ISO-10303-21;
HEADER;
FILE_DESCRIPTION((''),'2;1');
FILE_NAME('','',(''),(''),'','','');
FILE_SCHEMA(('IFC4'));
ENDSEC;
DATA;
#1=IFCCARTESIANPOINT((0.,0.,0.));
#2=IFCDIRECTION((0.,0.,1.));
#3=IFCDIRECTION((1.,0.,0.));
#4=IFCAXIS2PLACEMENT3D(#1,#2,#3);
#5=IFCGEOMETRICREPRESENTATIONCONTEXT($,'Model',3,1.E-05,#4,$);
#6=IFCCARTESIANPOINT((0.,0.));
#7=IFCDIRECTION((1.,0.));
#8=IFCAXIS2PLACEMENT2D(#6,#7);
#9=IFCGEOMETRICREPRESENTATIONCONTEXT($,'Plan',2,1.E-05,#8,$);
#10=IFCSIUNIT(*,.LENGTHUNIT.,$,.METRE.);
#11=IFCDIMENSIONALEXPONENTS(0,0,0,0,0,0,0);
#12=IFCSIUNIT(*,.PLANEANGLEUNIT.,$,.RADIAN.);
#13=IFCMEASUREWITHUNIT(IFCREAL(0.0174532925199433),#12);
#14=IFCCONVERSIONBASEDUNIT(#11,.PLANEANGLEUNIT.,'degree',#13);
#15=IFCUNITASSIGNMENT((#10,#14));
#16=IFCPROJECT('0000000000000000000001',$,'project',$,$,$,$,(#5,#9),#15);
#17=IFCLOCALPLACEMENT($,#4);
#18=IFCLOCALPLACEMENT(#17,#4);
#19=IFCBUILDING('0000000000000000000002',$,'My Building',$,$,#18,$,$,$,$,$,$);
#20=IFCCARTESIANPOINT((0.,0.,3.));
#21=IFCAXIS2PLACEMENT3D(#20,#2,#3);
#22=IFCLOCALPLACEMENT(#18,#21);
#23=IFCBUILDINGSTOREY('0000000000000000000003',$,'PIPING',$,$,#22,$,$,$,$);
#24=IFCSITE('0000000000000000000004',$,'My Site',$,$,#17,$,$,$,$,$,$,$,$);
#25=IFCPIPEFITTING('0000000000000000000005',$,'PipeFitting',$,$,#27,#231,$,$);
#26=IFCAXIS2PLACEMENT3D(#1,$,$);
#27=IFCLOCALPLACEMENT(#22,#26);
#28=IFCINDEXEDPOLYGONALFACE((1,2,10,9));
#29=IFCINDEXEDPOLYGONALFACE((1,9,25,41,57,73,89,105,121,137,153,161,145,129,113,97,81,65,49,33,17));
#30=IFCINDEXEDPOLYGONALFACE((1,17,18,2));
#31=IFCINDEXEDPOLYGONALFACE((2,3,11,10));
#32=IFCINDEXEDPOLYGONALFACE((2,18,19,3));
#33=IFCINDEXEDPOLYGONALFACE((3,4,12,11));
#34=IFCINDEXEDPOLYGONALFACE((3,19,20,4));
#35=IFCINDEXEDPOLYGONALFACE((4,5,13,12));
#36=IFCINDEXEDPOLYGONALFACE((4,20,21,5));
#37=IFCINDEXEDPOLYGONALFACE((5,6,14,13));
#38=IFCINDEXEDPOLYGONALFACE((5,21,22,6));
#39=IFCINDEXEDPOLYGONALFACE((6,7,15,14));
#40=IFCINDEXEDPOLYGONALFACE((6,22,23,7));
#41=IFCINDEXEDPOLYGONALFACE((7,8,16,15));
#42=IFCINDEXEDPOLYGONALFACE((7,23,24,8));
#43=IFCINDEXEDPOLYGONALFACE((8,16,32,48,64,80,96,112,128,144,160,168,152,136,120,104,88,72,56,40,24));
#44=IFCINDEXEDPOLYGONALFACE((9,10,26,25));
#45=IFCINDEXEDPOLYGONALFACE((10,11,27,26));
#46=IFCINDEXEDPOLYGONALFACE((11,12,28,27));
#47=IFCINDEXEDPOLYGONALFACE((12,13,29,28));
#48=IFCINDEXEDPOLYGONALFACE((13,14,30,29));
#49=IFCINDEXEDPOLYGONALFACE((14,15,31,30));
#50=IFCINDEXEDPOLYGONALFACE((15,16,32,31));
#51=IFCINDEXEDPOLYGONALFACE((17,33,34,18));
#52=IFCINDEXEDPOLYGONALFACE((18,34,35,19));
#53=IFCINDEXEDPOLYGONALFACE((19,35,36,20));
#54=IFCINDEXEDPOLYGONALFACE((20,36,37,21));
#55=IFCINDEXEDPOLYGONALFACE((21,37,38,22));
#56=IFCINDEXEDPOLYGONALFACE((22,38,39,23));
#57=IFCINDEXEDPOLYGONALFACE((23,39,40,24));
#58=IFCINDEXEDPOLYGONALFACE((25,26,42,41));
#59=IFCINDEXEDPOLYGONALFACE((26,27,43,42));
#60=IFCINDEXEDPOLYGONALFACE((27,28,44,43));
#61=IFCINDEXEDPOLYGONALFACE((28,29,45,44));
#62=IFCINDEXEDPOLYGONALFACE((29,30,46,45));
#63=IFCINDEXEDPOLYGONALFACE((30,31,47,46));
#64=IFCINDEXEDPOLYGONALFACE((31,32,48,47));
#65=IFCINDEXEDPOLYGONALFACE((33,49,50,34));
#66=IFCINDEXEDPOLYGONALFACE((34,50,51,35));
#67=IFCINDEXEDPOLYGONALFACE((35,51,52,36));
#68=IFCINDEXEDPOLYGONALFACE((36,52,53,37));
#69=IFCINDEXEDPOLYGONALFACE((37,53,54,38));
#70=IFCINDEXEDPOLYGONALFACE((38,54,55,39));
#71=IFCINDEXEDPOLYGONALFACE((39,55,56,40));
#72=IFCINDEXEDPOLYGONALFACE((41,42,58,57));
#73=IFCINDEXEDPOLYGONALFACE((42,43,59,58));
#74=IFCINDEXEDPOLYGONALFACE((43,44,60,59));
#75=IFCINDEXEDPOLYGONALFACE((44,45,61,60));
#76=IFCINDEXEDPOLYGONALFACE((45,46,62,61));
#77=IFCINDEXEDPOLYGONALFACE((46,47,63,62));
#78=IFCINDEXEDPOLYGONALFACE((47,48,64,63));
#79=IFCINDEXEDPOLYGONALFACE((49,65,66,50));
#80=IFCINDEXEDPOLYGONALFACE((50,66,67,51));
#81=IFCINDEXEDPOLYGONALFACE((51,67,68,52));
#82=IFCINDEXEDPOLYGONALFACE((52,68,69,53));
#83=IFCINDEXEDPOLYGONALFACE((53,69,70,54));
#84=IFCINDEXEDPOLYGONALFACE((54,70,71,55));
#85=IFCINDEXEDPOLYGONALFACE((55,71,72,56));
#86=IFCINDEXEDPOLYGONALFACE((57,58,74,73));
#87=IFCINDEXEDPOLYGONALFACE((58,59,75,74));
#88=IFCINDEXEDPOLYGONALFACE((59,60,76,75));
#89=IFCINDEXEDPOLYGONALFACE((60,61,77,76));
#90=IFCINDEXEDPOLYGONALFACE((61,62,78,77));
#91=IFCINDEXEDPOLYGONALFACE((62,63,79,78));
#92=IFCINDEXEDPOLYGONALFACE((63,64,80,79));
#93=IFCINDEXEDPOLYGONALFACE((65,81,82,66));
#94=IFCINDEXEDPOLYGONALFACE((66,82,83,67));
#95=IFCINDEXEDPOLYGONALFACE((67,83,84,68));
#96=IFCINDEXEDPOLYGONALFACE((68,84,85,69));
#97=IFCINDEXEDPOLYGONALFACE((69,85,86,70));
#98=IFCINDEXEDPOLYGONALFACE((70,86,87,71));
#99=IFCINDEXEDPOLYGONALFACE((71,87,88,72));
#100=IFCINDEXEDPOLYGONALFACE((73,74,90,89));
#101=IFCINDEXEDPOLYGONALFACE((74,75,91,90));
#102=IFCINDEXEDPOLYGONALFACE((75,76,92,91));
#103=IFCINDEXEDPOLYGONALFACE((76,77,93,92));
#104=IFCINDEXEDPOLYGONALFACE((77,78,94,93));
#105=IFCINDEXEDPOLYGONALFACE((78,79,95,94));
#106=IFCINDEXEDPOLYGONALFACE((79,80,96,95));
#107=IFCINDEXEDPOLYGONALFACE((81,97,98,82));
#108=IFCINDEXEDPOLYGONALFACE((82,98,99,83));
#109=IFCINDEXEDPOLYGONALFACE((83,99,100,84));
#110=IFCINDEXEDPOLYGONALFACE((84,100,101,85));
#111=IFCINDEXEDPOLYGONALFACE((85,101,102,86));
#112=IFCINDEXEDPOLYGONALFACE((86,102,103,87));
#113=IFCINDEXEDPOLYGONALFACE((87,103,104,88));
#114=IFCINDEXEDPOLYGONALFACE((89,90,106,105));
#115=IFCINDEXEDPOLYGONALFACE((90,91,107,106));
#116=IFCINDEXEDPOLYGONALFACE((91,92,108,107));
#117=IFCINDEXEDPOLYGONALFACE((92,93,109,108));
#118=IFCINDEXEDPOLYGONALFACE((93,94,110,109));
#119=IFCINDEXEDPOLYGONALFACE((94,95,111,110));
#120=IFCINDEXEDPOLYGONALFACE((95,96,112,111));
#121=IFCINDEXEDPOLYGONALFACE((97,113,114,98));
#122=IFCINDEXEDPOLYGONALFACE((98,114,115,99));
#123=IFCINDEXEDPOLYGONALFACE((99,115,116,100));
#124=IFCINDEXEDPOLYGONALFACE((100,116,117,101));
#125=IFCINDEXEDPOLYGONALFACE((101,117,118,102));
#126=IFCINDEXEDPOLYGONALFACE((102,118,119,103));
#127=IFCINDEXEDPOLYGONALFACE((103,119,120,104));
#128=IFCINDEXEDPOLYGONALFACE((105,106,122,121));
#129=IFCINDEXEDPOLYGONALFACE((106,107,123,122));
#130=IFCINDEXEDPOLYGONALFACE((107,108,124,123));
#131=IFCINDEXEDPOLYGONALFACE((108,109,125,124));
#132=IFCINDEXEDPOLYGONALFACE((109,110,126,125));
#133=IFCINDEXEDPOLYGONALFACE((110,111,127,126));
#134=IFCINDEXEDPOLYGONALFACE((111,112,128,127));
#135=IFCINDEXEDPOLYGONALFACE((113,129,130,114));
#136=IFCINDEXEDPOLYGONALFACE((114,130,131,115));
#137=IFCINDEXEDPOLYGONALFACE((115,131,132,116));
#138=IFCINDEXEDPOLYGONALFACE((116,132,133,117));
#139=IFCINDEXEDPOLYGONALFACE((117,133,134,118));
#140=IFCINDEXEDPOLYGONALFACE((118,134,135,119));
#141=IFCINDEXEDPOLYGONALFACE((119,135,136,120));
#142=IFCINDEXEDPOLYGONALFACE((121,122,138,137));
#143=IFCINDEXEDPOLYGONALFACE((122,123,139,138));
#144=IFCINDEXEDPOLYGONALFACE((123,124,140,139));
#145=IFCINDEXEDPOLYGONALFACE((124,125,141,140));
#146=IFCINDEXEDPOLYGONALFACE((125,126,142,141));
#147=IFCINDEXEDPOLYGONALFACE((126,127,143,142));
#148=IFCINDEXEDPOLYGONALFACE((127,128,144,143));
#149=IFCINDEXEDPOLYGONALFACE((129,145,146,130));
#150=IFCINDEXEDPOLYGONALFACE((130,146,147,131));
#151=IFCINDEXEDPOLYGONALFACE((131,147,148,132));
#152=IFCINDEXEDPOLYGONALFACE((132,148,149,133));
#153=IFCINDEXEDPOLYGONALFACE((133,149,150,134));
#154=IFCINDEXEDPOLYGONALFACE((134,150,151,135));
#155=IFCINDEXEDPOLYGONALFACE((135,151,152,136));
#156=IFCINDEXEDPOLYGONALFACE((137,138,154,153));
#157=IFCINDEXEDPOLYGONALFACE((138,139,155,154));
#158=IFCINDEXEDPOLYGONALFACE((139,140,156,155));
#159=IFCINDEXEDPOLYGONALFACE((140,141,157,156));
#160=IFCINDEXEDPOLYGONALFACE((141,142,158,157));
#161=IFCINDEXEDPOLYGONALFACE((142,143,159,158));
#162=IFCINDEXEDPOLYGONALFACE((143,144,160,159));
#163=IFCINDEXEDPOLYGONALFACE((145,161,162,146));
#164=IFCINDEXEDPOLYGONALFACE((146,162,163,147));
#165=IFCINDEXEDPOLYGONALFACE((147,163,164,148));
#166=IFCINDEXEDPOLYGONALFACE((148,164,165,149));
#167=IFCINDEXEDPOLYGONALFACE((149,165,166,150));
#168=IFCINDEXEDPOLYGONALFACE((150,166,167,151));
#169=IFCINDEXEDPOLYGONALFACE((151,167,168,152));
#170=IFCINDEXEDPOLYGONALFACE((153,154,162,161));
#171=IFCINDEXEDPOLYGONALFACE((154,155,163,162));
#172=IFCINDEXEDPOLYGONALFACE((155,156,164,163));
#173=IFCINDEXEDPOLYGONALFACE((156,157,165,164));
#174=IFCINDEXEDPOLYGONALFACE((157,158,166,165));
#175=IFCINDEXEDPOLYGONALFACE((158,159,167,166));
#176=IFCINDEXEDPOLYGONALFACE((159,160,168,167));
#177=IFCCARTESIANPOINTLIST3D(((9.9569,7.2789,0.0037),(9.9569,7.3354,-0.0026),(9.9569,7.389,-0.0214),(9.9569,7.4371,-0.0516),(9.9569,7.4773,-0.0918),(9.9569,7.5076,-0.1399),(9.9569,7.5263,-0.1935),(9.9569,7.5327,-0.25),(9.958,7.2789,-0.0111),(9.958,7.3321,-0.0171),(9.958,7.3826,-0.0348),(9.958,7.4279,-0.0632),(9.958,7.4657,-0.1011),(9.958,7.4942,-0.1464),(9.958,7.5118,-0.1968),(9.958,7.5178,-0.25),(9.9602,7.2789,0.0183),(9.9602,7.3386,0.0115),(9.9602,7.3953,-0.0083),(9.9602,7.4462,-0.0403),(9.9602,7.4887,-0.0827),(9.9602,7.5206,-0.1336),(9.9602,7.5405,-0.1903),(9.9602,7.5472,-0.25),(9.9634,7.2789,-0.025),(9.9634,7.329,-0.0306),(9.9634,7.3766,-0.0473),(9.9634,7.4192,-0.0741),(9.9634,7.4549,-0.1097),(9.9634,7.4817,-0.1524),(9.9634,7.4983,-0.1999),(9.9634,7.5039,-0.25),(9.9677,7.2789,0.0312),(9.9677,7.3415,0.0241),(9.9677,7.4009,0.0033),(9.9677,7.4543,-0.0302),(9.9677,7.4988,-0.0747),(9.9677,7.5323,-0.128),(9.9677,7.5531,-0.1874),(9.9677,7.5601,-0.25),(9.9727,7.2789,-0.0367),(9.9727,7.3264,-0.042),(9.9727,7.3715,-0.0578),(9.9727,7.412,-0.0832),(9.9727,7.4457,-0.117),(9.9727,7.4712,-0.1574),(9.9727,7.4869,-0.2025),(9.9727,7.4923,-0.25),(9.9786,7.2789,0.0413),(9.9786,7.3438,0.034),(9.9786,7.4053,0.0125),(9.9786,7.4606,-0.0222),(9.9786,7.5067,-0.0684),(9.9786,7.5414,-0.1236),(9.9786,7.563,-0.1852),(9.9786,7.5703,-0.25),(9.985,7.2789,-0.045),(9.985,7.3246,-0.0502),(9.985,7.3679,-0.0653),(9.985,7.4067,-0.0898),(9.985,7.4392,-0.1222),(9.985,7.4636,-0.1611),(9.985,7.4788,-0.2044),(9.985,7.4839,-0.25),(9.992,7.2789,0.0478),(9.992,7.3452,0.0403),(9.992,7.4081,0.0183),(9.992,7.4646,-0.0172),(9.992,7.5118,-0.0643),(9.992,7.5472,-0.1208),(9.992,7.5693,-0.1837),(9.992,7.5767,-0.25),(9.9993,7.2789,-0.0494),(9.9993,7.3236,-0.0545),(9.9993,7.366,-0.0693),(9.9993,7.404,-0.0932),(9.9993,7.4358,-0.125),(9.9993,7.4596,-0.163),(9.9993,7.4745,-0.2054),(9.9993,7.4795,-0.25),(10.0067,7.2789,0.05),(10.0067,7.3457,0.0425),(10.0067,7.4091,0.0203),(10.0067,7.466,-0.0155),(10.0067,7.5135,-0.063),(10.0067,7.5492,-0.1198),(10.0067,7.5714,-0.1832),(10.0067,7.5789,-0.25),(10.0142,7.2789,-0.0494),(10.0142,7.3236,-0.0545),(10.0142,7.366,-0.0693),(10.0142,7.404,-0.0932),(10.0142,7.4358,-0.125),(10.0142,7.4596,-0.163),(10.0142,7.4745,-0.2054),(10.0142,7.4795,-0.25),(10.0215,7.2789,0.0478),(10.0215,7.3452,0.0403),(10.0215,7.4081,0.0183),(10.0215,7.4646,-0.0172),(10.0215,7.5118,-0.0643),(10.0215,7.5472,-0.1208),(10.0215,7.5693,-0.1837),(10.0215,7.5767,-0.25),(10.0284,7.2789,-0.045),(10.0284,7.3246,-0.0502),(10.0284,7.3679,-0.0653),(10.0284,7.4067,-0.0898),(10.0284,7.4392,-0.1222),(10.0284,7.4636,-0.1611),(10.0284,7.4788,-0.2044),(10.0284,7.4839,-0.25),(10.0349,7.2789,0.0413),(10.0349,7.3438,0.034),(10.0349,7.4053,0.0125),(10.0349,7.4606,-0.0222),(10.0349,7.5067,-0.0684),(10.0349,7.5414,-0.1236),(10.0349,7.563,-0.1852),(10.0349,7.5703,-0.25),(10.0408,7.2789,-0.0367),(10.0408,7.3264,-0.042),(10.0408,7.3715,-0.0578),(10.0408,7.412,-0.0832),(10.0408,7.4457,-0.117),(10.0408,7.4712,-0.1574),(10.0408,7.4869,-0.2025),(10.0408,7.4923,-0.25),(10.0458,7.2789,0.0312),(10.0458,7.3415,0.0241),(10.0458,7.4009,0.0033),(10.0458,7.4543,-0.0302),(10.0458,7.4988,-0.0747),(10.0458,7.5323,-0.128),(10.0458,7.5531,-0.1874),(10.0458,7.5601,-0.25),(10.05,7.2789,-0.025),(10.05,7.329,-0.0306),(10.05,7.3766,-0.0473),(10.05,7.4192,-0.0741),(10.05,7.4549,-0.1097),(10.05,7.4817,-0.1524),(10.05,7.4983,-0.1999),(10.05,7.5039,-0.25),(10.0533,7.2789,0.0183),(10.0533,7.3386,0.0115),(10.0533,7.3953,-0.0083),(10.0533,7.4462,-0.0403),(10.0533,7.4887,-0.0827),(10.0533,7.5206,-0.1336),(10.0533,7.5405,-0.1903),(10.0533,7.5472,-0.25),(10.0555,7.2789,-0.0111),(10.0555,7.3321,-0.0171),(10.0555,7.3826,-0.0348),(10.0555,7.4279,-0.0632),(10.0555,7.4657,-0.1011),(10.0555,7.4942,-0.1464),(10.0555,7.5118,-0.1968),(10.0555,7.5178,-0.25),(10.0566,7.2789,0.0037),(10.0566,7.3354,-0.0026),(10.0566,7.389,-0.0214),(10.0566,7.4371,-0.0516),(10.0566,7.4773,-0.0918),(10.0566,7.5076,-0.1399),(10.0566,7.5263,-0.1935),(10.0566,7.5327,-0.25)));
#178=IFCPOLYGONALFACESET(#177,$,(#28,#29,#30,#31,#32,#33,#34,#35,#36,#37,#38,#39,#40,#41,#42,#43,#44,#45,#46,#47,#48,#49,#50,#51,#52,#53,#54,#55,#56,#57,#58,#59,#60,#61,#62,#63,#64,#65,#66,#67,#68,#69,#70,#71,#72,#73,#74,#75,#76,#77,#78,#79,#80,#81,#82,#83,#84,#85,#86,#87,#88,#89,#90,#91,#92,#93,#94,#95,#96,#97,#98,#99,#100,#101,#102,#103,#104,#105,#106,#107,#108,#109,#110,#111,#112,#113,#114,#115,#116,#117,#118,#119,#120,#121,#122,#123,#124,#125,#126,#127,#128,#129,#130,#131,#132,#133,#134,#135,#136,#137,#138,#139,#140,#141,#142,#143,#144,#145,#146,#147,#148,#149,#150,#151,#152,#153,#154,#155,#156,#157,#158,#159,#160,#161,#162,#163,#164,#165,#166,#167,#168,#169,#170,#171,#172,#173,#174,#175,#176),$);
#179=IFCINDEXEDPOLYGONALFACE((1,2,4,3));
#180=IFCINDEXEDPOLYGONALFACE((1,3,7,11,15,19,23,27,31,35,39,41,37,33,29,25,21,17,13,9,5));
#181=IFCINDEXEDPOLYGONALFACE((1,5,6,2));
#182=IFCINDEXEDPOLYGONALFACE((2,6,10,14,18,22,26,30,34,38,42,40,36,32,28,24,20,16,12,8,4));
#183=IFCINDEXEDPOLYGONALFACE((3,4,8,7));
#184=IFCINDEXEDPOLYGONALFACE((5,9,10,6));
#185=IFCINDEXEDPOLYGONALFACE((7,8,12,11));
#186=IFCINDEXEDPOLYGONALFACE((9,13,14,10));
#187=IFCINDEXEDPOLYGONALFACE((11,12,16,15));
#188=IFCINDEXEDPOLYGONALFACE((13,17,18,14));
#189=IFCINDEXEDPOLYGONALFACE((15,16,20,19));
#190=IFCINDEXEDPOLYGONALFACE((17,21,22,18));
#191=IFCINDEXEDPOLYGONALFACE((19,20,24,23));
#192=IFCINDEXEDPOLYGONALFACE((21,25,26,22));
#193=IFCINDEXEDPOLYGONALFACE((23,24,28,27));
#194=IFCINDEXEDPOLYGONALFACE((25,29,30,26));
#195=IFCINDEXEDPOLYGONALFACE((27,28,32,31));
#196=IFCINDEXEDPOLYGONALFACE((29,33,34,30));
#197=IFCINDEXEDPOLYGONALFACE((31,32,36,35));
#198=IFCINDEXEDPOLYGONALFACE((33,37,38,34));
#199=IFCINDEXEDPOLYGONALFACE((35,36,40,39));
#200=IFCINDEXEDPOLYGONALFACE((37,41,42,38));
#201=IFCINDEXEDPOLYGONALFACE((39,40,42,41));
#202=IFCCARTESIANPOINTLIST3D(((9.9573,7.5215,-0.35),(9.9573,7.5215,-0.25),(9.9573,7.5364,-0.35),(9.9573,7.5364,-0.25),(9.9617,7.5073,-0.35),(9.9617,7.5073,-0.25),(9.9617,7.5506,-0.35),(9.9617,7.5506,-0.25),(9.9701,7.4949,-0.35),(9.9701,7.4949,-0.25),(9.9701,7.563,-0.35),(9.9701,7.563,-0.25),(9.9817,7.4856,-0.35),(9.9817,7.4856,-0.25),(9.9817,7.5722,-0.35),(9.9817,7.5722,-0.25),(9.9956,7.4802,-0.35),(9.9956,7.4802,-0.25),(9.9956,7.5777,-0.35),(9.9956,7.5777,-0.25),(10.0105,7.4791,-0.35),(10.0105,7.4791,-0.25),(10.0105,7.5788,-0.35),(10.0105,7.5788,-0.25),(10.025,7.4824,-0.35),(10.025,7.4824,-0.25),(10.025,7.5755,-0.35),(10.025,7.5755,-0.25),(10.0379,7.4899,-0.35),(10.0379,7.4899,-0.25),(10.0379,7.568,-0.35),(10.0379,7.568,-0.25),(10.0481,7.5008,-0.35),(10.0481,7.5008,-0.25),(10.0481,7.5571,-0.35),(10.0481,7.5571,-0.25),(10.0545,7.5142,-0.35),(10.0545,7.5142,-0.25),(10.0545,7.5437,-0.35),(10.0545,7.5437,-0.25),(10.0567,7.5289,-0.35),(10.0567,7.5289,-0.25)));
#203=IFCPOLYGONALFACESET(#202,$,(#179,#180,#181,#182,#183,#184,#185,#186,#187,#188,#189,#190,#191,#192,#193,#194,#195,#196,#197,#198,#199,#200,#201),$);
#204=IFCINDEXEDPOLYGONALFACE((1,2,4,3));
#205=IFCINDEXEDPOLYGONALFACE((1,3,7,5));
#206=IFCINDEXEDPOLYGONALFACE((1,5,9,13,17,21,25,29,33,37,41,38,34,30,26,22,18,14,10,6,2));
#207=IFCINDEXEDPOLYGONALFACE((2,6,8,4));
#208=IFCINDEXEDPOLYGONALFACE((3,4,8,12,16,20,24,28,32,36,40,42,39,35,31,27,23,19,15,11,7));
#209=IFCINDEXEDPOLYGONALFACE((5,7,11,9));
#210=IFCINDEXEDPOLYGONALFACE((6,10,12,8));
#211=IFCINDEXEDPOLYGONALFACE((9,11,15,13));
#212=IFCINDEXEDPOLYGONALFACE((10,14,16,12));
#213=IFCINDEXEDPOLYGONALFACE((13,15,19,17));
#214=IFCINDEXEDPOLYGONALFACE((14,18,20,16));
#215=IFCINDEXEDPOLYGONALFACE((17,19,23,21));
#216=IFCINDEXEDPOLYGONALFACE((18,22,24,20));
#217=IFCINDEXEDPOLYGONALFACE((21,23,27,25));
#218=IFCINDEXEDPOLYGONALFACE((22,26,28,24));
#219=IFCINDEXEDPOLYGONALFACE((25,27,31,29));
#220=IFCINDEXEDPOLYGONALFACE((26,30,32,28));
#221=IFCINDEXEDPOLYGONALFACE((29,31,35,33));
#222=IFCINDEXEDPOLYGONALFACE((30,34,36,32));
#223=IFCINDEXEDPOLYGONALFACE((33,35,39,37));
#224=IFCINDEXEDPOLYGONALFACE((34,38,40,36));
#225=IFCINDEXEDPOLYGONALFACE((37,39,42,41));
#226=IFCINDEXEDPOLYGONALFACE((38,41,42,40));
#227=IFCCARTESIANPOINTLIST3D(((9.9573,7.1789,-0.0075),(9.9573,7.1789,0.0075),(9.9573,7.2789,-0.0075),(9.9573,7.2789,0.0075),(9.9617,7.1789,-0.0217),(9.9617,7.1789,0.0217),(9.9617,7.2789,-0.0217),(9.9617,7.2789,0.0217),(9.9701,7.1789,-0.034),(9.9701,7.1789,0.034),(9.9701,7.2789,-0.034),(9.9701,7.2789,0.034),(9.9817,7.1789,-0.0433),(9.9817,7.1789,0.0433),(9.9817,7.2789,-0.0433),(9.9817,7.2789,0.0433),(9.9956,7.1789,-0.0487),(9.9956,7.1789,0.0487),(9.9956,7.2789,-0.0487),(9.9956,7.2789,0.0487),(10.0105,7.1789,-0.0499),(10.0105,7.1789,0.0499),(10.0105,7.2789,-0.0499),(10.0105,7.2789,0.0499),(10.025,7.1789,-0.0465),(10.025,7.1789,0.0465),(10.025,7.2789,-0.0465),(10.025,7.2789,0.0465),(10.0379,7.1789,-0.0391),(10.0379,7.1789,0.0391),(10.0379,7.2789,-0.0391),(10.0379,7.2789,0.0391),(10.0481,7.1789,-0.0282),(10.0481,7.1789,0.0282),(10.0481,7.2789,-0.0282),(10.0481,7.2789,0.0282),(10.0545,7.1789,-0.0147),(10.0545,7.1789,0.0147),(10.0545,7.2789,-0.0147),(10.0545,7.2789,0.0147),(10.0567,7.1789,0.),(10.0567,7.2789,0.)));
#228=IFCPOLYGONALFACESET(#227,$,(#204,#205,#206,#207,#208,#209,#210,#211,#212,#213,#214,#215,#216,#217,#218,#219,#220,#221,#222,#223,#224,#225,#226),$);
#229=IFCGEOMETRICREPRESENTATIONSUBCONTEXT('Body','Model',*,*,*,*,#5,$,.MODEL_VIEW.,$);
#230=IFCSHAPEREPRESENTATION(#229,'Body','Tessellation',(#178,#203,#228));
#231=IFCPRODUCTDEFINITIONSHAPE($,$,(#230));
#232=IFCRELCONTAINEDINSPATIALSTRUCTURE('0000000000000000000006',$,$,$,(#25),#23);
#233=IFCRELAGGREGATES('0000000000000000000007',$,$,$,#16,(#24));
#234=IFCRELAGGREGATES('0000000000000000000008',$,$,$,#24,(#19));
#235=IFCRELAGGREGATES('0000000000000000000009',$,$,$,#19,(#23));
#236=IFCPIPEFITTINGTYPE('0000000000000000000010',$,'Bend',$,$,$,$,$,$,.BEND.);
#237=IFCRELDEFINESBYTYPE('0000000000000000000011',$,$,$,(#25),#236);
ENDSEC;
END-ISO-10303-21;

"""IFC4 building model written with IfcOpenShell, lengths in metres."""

from ifc_helpers import new_model, entity, si_unit, converted_unit, frame, origin_with_axes, origin_2d_with_axis, place, context, subcontext, project, spatial, circle, extrude, source, transform, mapped, type_object, type_shapes, element, save


model = new_model("IFC4")

# Units and contexts
model_context = context("Model", 3, precision=1e-05, world=origin_with_axes())
plan_context = context("Plan", 2, precision=1e-05, world=origin_2d_with_axis())
body_context = subcontext(model_context, "Body", "Model", "MODEL_VIEW")
ifc_project = project(units=[si_unit("LENGTHUNIT", "METRE"), converted_unit("PLANEANGLEUNIT", "degree", entity("IfcReal", 0.0174532925199433), si_unit("PLANEANGLEUNIT", "RADIAN"), dimensions=[0, 0, 0, 0, 0, 0, 0])], contexts=[model_context, plan_context])

# Site, building, storey
site_placement = place(None, origin_with_axes())
site = spatial("IfcSite", under=ifc_project, at=site_placement, Name="My Site")
building_placement = place(site_placement, origin_with_axes())
building = spatial("IfcBuilding", under=site, at=building_placement, Name="My Building")
storey_placement = place(building_placement, frame((0.0, 0.0, 3.0), z_axis=(0.0, 0.0, 1.0), x_axis=(1.0, 0.0, 0.0)))
storey = spatial("IfcBuildingStorey", under=building, at=storey_placement, Name="PIPING")

# Pipe fitting
pipe_fitting_type_1 = type_object("IfcPipeFittingType", Name="Bend", PredefinedType="BEND")
shared_shape = source(origin_with_axes(), body_context, "Body", "SolidModel", [
    entity("IfcSweptDiskSolid", entity("IfcIndexedPolyCurve", entity("IfcCartesianPointList3D", [[0.0, 0.0, -0.1], [0.0, 0.0732, -0.2768], [0.0, 0.25, -0.35]]), [entity("IfcArcIndex", [1, 2, 3])]), 0.05),
    extrude(circle(Radius=0.05), origin_with_axes(), (0.0, 0.0, -1.0), 0.1),
    extrude(circle(Radius=0.05), frame((0.0, 0.25, -0.35), z_axis=(0.0, 1.0, 0.0), x_axis=(1.0, 0.0, 0.0)), (0.0, 0.0, 1.0), 0.1),
])
type_shapes(pipe_fitting_type_1, [shared_shape])
for number, where, z_axis, x_axis, name in (
    (1, (10.0067, 7.5289, -0.35), (0.0, 0.0, -1.0), (1.0, 0.0, 0.0), "PipeFitting"),
):
    element("IfcPipeFitting", number, at=place(storey_placement, frame(where, z_axis=z_axis, x_axis=x_axis)), inside=storey, type_object=pipe_fitting_type_1, Name=name, context=body_context, shape_type="MappedRepresentation", body=[
        mapped(shared_shape, transform((0.0, 0.0, 0.0), x_axis=(1.0, 0.0, 0.0), y_axis=(0.0, 1.0, 0.0), z_axis=(0.0, 0.0, 1.0), scale=1.0)),
    ])

save(model, "model.ifc")
